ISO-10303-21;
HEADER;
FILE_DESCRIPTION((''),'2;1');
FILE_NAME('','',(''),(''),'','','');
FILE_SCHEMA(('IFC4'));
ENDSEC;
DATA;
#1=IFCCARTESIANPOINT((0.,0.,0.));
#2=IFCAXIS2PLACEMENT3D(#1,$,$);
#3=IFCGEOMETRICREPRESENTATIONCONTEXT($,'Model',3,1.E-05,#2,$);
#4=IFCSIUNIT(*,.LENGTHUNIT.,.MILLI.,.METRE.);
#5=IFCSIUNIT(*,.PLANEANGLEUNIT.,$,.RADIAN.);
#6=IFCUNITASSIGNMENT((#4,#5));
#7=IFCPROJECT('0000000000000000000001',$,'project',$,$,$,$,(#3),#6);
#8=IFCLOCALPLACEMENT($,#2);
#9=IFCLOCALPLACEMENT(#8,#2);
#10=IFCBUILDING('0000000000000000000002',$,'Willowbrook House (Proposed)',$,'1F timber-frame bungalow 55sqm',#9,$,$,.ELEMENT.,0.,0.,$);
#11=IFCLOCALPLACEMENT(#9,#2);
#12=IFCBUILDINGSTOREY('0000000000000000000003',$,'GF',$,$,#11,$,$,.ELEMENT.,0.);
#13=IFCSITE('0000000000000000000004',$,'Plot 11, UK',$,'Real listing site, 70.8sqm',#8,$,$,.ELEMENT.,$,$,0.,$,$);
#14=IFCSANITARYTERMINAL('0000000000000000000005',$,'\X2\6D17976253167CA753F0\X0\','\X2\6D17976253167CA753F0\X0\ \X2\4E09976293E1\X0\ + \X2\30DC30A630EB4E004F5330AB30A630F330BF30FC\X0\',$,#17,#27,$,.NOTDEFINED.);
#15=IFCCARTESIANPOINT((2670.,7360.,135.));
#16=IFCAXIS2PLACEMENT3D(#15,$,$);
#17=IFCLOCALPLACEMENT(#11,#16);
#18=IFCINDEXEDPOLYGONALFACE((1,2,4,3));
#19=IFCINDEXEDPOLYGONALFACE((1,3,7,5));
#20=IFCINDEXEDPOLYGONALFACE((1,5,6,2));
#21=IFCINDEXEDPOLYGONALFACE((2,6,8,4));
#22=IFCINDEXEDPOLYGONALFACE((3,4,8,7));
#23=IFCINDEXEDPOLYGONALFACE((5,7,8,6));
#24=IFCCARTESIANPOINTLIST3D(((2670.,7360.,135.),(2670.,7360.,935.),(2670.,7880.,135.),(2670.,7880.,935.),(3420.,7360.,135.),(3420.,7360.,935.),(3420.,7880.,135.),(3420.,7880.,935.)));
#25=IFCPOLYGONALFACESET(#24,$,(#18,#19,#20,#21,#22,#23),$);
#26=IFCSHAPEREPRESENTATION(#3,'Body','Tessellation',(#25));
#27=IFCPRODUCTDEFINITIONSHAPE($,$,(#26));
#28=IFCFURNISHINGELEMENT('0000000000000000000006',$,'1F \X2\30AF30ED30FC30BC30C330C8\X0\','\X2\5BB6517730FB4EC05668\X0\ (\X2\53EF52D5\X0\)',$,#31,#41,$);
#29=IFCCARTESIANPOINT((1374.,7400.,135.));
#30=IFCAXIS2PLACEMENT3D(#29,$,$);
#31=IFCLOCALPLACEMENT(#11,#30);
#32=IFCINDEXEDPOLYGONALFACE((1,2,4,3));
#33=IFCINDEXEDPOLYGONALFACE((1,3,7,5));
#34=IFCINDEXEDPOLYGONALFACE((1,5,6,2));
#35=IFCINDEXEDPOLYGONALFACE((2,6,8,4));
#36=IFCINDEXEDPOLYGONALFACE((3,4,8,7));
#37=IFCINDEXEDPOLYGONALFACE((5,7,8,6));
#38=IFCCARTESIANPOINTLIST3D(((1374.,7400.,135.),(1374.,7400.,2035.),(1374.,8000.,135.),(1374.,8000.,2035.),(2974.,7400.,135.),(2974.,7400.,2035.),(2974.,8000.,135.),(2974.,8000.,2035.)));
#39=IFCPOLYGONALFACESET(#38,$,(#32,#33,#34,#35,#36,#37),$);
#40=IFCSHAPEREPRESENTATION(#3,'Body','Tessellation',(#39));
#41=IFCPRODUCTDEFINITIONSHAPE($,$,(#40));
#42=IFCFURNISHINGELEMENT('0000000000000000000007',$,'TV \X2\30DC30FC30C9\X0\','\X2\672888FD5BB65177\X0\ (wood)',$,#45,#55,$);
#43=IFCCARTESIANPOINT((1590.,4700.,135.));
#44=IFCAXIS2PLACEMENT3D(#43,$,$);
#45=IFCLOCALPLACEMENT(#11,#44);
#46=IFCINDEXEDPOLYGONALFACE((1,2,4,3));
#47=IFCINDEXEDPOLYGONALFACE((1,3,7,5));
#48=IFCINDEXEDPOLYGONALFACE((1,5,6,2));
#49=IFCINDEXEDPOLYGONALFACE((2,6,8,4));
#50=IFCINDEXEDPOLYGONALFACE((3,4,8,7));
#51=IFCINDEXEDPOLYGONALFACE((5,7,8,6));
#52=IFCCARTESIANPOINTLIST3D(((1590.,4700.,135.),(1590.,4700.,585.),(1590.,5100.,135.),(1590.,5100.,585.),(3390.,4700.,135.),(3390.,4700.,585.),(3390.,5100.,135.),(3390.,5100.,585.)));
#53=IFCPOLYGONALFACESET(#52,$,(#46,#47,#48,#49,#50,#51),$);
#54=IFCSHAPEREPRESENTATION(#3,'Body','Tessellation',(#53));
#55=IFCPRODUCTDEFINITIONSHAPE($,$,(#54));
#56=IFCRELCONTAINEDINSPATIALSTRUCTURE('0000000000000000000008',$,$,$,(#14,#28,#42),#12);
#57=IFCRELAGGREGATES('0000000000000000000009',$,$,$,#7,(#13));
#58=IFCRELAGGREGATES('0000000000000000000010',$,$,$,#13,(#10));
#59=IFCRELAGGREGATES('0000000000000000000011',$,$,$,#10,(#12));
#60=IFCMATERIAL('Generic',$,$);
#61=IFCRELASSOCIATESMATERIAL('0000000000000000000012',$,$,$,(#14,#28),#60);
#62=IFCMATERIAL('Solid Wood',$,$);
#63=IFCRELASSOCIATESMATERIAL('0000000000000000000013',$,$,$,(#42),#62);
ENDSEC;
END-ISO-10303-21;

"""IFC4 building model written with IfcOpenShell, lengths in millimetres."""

from ifc_helpers import new_model, si_unit, frame, frame_2d, origin, place, context, project, spatial, rectangle, extrude, material, element, save


model = new_model("IFC4")

# Units and contexts
model_context = context("Model", 3, precision=1e-05, world=origin())
ifc_project = project(units=[si_unit("LENGTHUNIT", "METRE", prefix="MILLI"), si_unit("PLANEANGLEUNIT", "RADIAN")], contexts=[model_context])

# Site, building, storey
site_placement = place(None, origin())
site = spatial("IfcSite", under=ifc_project, at=site_placement, Name="Plot 11, UK", ObjectType="Real listing site, 70.8sqm", CompositionType="ELEMENT", RefElevation=0.0)
building_placement = place(site_placement, origin())
building = spatial("IfcBuilding", under=site, at=building_placement, Name="Willowbrook House (Proposed)", ObjectType="1F timber-frame bungalow 55sqm", CompositionType="ELEMENT", ElevationOfRefHeight=0.0, ElevationOfTerrain=0.0)
storey_placement = place(building_placement, origin())
storey = spatial("IfcBuildingStorey", under=building, at=storey_placement, Name="GF", CompositionType="ELEMENT", Elevation=0.0)

# Shared definitions
ifc_material_1 = material(Name="Solid Wood")

# Shared definitions
ifc_material_2 = material(Name="Generic")

# Sanitary terminal
sanitary_terminal_1_placement = place(storey_placement, frame((2670.0, 7360.0, 135.0)))
element("IfcSanitaryTerminal", 1, at=sanitary_terminal_1_placement, inside=storey, material=ifc_material_2, Name="洗面化粧台", Description="洗面化粧台 三面鏡 + ボウル一体カウンター", PredefinedType="NOTDEFINED", context=model_context, shape_type="SweptSolid", body=[
    extrude(rectangle(XDim=750.0, YDim=520.0, at=frame_2d((375.0, 260.0))), frame((2670.0, 7360.0, 135.0)), (0.0, 0.0, 1.0), 800.0),
])

# Furnishing elements
furnishing_1_placement = place(storey_placement, frame((1374.0, 7400.0, 135.0)))
element("IfcFurnishingElement", 2, at=furnishing_1_placement, inside=storey, material=ifc_material_2, Name="1F クローゼット", Description="家具・什器 (可動)", context=model_context, shape_type="SweptSolid", body=[
    extrude(rectangle(XDim=1600.0, YDim=600.0, at=frame_2d((800.0, 300.0))), frame((1374.0, 7400.0, 135.0)), (0.0, 0.0, 1.0), 1900.0),
])
furnishing_2_placement = place(storey_placement, frame((1590.0, 4700.0, 135.0)))
element("IfcFurnishingElement", 3, at=furnishing_2_placement, inside=storey, material=ifc_material_1, Name="TV ボード", Description="木製家具 (wood)", context=model_context, shape_type="SweptSolid", body=[
    extrude(rectangle(XDim=1800.0, YDim=400.0, at=frame_2d((900.0, 200.0))), frame((1590.0, 4700.0, 135.0)), (0.0, 0.0, 1.0), 450.0),
])

save(model, "model.ifc")
